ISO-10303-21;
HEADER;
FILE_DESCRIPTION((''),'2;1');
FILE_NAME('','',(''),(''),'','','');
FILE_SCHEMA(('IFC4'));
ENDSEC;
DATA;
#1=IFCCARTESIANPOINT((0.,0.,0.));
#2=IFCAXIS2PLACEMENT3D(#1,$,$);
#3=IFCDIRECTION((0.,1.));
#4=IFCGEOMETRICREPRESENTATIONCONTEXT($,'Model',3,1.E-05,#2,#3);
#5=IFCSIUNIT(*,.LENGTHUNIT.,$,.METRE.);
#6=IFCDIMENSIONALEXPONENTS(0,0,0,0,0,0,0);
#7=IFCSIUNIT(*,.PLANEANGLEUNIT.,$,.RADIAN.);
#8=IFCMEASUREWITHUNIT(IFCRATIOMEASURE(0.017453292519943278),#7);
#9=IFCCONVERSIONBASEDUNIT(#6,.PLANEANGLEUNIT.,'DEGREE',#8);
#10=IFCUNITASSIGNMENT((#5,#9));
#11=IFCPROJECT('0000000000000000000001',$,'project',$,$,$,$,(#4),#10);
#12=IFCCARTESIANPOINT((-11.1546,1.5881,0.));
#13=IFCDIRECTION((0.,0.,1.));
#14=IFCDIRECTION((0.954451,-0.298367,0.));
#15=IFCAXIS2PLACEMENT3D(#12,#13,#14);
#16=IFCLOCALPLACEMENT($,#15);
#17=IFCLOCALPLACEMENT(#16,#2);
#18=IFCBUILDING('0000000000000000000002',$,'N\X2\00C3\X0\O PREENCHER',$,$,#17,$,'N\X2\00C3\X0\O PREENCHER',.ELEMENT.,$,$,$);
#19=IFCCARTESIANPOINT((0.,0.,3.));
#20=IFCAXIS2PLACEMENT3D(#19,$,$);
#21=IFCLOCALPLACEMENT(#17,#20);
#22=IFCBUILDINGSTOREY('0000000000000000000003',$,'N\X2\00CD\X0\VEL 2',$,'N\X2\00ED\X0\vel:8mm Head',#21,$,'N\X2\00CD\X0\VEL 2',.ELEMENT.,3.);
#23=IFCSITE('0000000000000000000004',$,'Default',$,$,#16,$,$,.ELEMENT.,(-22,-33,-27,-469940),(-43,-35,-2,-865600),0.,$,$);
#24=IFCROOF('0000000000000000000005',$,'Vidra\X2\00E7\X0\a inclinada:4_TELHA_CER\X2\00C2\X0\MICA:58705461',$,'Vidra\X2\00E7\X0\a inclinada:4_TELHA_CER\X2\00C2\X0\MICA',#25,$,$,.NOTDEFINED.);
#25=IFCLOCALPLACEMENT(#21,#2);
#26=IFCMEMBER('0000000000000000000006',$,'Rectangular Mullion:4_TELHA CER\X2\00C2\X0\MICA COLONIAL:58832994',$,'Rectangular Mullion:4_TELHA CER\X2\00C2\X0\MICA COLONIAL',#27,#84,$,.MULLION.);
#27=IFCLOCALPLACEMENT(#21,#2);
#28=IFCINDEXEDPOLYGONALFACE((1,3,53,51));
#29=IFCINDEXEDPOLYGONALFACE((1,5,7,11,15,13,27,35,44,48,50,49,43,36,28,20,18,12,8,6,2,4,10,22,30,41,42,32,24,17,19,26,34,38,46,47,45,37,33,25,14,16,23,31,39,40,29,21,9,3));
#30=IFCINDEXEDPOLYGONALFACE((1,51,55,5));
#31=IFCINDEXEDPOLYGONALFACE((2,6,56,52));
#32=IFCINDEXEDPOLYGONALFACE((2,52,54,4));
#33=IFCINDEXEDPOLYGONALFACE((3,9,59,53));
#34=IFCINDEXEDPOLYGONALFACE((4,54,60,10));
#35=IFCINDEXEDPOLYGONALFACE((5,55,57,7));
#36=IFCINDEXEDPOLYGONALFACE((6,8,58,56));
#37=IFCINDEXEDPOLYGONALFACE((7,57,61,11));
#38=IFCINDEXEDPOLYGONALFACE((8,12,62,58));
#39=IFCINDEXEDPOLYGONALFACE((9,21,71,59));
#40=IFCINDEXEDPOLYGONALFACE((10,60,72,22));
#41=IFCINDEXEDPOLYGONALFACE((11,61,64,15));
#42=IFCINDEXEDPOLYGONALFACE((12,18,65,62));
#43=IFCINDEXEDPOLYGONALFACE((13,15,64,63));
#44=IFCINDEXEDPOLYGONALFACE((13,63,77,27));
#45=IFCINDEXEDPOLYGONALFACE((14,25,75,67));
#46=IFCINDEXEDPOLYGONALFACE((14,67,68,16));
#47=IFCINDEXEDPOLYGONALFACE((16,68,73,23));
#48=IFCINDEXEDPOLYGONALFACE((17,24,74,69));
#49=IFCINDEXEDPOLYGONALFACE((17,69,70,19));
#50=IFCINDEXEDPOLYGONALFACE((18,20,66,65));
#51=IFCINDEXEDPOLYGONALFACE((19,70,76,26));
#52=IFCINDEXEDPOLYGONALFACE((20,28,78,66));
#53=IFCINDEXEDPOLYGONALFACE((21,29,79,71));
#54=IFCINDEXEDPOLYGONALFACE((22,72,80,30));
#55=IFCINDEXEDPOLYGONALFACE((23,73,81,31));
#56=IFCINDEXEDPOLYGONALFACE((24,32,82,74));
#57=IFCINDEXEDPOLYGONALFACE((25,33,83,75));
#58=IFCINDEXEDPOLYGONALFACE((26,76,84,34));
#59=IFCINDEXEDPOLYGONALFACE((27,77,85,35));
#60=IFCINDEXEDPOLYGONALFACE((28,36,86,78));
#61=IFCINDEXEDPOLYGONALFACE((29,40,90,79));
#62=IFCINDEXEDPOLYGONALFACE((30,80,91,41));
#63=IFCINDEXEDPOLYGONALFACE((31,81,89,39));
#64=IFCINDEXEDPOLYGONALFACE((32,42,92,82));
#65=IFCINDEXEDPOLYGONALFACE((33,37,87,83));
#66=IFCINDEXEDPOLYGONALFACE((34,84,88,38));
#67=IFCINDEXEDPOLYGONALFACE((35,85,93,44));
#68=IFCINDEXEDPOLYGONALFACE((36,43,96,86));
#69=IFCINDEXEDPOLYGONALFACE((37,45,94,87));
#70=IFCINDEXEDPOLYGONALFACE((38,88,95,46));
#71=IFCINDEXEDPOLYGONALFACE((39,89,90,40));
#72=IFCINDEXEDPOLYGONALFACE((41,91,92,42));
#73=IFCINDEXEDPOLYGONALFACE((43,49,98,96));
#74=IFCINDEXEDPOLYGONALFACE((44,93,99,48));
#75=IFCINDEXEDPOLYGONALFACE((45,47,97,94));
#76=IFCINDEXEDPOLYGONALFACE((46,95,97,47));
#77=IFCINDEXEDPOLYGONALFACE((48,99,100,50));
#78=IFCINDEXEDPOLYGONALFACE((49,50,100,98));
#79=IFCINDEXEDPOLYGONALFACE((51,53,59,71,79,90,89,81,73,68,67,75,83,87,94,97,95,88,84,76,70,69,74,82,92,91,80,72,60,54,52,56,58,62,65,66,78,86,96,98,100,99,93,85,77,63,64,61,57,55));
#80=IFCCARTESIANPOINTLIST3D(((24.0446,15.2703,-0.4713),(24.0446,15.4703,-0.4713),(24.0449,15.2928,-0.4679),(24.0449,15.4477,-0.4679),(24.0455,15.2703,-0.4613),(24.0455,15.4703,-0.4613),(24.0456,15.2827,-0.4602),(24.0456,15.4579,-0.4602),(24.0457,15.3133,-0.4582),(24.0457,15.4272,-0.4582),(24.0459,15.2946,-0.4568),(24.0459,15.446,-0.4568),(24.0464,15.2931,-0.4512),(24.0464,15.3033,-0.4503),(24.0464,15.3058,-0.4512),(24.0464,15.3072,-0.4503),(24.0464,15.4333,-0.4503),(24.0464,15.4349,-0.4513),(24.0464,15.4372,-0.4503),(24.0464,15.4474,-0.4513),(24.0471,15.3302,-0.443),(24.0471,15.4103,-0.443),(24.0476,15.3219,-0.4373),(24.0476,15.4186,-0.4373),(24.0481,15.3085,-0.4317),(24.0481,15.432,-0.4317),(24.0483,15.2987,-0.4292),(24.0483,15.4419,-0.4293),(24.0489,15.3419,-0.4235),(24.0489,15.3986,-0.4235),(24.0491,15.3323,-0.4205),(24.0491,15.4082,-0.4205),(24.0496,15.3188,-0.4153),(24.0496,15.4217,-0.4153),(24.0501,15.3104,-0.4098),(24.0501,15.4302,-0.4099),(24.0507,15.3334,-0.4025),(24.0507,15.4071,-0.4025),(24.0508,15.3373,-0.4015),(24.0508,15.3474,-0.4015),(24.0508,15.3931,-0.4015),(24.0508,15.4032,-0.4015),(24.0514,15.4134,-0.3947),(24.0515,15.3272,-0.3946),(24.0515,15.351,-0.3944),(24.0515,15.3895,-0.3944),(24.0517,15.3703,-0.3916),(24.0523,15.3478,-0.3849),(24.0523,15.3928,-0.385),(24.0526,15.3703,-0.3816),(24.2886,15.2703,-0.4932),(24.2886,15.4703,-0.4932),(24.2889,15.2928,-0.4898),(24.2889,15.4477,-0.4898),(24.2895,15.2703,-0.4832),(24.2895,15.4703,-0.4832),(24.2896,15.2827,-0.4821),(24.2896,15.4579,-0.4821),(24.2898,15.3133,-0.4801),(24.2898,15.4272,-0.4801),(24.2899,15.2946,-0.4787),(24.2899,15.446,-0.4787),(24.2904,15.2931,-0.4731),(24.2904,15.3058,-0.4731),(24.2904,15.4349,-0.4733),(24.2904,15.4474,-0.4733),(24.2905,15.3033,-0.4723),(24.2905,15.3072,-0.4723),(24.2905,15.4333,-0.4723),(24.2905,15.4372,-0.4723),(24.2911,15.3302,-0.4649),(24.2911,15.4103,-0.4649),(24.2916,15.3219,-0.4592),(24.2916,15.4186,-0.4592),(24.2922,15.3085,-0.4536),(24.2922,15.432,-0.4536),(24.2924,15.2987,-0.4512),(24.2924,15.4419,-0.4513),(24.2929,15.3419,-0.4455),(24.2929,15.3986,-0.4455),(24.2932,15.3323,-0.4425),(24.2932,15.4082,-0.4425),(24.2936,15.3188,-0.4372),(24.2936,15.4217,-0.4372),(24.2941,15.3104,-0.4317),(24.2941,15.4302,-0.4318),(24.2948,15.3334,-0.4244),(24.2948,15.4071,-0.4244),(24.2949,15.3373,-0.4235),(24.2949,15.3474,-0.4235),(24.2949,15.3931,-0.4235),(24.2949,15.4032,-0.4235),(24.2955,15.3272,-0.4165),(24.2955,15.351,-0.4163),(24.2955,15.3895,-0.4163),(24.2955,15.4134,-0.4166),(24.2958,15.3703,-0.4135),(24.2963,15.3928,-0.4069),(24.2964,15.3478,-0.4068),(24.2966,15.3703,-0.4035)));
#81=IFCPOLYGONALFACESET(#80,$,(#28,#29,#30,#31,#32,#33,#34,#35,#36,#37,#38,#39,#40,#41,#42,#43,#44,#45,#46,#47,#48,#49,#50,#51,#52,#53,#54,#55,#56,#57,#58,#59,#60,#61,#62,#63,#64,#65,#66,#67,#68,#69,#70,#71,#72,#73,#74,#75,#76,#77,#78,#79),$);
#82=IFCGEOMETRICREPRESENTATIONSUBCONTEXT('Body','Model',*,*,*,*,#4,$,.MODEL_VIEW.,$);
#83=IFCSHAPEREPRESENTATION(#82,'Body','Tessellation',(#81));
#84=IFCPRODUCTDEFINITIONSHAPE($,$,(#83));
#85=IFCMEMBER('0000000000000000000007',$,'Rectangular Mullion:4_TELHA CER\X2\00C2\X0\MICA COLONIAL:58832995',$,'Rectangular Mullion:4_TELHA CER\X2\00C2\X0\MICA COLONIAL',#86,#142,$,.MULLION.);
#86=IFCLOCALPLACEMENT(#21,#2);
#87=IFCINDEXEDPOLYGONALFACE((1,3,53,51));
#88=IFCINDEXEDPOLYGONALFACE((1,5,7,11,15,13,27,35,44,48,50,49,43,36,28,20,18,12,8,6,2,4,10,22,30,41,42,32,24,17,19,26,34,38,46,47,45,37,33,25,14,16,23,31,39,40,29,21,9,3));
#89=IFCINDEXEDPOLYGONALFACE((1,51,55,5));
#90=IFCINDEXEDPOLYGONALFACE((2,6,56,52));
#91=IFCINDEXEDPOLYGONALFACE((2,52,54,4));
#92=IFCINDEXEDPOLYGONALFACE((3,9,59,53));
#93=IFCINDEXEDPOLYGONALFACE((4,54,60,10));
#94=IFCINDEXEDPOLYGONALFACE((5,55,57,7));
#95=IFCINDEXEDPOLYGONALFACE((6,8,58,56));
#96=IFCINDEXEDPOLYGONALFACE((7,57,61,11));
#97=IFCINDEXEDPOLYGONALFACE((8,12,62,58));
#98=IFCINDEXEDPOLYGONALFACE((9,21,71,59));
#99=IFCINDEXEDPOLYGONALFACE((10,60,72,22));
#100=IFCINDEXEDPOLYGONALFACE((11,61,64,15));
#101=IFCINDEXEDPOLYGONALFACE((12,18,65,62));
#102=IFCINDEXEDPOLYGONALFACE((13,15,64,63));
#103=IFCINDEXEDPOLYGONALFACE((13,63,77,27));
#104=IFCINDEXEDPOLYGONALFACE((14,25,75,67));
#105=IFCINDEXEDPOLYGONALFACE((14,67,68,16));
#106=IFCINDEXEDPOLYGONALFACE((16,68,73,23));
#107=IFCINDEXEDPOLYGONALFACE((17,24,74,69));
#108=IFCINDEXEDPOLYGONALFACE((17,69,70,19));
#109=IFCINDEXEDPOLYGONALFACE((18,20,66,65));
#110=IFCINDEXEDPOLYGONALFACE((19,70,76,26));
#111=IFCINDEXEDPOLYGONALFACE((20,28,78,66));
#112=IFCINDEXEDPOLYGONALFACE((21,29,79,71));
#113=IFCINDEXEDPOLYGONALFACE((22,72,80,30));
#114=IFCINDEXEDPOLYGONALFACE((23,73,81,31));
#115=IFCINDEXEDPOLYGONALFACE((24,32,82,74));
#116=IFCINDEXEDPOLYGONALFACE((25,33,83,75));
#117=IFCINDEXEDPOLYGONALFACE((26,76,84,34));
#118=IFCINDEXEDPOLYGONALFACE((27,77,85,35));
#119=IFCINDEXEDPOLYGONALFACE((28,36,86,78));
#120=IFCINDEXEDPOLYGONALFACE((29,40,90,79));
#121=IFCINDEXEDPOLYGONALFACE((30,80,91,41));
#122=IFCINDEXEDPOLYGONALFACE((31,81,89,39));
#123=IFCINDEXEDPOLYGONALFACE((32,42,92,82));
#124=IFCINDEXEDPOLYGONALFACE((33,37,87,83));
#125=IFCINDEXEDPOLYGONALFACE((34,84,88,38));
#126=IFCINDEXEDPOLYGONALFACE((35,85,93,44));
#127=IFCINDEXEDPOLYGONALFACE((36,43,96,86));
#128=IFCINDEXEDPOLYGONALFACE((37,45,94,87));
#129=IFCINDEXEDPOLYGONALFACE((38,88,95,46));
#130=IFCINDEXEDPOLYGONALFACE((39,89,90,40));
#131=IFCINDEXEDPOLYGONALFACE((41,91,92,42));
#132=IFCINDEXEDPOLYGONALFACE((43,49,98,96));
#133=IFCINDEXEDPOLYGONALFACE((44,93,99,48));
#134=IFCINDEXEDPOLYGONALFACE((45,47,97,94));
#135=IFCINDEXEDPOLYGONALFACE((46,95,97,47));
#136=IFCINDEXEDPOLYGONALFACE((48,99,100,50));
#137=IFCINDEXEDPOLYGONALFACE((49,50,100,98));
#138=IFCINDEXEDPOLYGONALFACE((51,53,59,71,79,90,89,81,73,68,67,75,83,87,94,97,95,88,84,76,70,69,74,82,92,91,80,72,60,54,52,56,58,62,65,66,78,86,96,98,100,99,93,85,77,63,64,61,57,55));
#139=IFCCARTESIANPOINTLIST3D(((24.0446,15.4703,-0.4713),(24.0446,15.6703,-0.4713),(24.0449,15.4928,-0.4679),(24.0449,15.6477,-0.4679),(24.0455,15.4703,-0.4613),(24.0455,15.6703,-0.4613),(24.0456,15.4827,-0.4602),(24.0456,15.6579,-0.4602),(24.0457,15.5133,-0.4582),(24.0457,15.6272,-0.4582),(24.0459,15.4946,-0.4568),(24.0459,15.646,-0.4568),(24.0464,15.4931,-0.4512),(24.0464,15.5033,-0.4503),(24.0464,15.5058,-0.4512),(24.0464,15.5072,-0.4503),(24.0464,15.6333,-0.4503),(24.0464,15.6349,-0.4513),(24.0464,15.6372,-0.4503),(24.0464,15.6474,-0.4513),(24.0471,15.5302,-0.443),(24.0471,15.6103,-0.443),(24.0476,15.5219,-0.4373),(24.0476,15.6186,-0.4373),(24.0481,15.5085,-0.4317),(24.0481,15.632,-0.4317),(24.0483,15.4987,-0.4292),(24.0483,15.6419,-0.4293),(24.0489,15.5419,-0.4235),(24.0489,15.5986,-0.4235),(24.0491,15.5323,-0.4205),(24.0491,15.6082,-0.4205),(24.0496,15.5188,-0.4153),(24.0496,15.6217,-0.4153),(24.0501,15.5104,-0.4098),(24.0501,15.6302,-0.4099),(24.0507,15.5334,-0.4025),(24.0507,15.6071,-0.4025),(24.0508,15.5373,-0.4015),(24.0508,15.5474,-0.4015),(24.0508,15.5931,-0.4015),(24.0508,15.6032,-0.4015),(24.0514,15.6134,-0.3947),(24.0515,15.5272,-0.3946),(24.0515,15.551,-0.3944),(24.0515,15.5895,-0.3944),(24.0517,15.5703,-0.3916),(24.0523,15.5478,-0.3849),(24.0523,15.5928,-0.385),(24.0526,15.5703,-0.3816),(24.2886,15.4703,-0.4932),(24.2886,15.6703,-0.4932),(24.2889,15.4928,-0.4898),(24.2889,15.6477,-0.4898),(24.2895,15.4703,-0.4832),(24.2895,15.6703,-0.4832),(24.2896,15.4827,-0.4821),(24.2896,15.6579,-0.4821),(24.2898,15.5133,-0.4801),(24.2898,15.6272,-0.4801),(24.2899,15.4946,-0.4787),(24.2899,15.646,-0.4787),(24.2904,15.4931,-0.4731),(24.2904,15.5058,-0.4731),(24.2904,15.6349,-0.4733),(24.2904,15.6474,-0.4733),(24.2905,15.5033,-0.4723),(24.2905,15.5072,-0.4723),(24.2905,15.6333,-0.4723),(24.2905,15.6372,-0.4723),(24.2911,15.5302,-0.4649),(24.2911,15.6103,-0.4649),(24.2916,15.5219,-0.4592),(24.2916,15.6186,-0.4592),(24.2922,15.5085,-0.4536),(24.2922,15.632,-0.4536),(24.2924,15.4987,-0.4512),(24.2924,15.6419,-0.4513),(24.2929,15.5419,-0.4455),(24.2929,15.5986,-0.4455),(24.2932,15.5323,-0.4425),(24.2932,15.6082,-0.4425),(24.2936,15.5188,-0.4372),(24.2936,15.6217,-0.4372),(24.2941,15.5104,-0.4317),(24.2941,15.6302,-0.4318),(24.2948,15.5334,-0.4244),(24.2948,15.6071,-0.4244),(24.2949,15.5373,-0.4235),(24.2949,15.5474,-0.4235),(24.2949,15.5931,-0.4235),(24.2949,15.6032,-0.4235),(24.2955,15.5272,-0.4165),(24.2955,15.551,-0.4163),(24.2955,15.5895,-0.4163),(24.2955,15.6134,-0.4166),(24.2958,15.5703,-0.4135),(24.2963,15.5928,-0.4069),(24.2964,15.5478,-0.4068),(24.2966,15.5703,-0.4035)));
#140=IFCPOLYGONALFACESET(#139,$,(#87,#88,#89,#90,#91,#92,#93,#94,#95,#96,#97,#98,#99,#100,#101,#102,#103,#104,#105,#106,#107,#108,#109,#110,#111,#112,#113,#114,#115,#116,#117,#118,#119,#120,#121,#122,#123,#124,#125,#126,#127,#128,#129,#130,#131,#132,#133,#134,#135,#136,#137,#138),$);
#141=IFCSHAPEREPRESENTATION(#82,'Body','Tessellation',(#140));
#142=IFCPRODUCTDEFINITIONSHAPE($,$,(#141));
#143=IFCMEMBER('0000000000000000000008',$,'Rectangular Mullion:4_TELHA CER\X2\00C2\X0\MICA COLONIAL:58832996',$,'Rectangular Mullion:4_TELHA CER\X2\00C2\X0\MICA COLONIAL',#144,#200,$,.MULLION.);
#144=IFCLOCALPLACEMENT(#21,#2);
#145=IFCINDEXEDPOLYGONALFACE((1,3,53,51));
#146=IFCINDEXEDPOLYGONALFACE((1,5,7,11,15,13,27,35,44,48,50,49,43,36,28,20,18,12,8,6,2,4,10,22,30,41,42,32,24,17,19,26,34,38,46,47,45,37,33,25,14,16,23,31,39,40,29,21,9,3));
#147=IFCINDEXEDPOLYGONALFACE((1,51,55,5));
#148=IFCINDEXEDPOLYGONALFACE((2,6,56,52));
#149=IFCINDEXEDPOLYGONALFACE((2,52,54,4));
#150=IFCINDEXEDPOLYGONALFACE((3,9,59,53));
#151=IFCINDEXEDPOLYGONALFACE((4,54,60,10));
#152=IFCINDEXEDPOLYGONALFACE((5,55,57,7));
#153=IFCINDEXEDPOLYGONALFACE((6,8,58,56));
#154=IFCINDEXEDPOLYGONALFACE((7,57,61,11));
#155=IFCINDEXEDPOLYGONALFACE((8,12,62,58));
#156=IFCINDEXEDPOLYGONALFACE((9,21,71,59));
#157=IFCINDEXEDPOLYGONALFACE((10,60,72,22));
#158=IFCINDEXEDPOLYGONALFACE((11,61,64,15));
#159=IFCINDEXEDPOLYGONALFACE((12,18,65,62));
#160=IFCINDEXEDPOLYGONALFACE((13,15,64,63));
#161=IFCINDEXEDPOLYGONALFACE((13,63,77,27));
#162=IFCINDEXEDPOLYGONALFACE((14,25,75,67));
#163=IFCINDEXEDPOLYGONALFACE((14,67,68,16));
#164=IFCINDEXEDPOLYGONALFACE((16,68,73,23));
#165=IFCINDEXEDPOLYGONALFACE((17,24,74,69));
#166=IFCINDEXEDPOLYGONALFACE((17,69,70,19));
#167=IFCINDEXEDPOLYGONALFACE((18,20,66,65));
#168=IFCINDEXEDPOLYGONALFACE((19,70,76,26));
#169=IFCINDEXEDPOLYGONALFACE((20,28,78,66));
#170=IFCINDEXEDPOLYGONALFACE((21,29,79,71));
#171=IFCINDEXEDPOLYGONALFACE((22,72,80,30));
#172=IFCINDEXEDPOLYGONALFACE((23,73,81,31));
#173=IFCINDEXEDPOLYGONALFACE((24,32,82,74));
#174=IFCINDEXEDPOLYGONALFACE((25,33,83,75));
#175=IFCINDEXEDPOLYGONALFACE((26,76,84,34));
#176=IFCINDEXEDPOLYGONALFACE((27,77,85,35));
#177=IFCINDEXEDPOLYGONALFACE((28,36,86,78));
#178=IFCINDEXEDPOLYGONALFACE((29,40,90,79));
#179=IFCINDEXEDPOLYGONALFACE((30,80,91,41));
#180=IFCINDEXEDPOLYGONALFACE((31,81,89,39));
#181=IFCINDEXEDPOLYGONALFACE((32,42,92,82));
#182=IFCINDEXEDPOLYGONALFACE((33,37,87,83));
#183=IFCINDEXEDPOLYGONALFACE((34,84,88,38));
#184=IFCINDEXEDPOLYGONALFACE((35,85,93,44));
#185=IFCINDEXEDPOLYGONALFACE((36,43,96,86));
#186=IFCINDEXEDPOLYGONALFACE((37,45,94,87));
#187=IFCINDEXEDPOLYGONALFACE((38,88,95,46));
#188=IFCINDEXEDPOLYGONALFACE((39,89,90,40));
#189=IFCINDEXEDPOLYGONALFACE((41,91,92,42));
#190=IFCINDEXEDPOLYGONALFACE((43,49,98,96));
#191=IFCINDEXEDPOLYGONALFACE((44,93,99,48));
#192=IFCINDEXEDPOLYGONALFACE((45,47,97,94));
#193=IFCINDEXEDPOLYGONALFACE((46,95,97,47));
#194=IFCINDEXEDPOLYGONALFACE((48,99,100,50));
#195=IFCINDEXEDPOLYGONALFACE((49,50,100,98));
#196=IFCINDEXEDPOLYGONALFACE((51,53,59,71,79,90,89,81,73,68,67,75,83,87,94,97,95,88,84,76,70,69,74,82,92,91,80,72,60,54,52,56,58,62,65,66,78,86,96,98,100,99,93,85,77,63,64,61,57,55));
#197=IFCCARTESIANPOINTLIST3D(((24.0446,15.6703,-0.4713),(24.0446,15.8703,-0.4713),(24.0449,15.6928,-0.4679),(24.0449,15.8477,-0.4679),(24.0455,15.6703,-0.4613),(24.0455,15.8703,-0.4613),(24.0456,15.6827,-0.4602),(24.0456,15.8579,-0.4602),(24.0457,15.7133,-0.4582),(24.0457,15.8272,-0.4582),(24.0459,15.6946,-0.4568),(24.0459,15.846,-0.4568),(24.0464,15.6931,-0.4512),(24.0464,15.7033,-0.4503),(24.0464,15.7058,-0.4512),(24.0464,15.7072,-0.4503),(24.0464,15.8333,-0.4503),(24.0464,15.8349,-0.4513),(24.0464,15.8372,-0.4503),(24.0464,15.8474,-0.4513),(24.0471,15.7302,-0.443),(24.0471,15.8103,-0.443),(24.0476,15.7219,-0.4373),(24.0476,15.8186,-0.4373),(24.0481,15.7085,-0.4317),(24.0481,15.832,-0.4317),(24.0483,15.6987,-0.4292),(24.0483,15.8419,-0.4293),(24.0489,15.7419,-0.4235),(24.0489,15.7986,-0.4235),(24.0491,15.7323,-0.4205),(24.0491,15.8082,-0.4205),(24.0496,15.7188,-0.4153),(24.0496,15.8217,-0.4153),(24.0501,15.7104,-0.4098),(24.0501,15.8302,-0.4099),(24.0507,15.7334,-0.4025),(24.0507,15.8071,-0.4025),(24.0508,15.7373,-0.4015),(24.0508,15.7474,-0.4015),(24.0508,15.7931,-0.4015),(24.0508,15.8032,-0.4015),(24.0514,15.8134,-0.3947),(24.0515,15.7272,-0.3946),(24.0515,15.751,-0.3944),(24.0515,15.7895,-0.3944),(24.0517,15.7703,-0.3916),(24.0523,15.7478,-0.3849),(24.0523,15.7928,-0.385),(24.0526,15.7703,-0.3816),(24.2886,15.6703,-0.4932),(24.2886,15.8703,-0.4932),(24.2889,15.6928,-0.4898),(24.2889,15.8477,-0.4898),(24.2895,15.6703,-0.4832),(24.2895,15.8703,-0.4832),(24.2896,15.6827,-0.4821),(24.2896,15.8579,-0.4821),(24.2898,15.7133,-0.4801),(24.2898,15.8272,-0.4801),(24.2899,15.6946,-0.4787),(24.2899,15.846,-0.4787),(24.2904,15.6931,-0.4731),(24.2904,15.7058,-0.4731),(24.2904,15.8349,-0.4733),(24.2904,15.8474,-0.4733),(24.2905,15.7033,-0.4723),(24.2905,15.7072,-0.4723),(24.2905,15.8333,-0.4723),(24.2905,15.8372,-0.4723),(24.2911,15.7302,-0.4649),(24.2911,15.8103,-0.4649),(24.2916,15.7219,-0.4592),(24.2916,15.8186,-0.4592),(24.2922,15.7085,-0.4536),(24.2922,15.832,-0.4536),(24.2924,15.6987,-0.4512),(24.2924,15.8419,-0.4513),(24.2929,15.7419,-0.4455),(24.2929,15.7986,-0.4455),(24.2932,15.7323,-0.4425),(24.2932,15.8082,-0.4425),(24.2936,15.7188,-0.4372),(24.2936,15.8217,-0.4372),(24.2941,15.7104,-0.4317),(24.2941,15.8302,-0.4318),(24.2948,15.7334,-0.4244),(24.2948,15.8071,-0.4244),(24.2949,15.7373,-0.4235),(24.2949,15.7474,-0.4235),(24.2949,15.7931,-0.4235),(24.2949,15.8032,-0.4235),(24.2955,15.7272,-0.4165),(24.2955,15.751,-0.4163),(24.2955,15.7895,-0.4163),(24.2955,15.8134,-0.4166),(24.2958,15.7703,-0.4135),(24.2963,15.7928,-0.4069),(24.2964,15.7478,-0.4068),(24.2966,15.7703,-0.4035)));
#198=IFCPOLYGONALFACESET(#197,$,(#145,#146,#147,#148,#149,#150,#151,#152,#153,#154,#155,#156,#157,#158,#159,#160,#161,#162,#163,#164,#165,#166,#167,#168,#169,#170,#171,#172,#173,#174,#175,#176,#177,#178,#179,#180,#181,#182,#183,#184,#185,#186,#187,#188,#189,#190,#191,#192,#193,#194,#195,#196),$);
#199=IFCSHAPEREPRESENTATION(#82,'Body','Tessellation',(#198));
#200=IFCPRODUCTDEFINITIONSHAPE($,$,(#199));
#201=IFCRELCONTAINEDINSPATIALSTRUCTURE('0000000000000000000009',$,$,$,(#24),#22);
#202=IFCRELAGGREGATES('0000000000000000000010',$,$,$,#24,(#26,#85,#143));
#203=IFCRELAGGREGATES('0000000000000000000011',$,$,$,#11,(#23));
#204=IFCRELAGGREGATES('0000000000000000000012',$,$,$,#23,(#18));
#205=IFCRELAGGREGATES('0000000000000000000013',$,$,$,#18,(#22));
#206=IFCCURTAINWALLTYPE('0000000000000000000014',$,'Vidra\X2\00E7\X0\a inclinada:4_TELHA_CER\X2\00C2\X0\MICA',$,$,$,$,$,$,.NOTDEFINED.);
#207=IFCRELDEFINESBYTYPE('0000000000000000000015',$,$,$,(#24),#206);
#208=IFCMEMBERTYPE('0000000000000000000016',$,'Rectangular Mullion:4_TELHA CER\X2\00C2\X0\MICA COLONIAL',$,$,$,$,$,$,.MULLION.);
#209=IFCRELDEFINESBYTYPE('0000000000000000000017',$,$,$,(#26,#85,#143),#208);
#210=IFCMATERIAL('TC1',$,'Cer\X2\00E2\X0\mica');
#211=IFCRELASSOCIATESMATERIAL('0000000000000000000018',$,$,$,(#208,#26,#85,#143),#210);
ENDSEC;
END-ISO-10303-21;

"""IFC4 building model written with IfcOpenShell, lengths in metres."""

from ifc_helpers import new_model, entity, si_unit, converted_unit, direction, frame, origin, place, context, subcontext, project, spatial, line, arc, indexed_curve, outline, extrude, source, transform, mapped, material, type_object, type_shapes, element, aggregate, save


model = new_model("IFC4")

# Units and contexts
model_context = context("Model", 3, precision=1e-05, world=origin(), true_north=direction((0.0, 1.0)))
body_context = subcontext(model_context, "Body", "Model", "MODEL_VIEW")
ifc_project = project(units=[si_unit("LENGTHUNIT", "METRE"), converted_unit("PLANEANGLEUNIT", "DEGREE", entity("IfcRatioMeasure", 0.017453292519943278), si_unit("PLANEANGLEUNIT", "RADIAN"), dimensions=[0, 0, 0, 0, 0, 0, 0])], contexts=[model_context])

# Site, building, storey
site_placement = place(None, frame((-11.1546, 1.5881, 0.0), z_axis=(0.0, 0.0, 1.0), x_axis=(0.954451, -0.298367, 0.0)))
site = spatial("IfcSite", under=ifc_project, at=site_placement, Name="Default", CompositionType="ELEMENT", RefLatitude=(-22, -33, -27, -469940), RefLongitude=(-43, -35, -2, -865600), RefElevation=0.0)
building_placement = place(site_placement, origin())
building = spatial("IfcBuilding", under=site, at=building_placement, Name="NÃO PREENCHER", LongName="NÃO PREENCHER", CompositionType="ELEMENT")
storey_placement = place(building_placement, frame((0.0, 0.0, 3.0)))
storey = spatial("IfcBuildingStorey", under=building, at=storey_placement, Name="NÍVEL 2", ObjectType="Nível:8mm Head", LongName="NÍVEL 2", CompositionType="ELEMENT", Elevation=3.0)

# Roof, members
curtain_wall_type = type_object("IfcCurtainWallType", Name="Vidraça inclinada:4_TELHA_CERÂMICA", PredefinedType="NOTDEFINED")
roof_placement = place(storey_placement, frame((0.0, 0.0, -3.0)))
roof = element("IfcRoof", 1, at=roof_placement, inside=storey, type_object=curtain_wall_type, Name="Vidraça inclinada:4_TELHA_CERÂMICA:58705461", ObjectType="Vidraça inclinada:4_TELHA_CERÂMICA", PredefinedType="NOTDEFINED")
ifc_material_1 = material(Name="TC1", Category="Cerâmica")
member_type_1 = type_object("IfcMemberType", Name="Rectangular Mullion:4_TELHA CERÂMICA COLONIAL", PredefinedType="MULLION", material=ifc_material_1)
shared_shape_1 = source(origin(), body_context, "Body", "SweptSolid", [
    extrude(outline(indexed_curve([(-0.029, -0.1), (-0.019, -0.1), (-0.0164, -0.0815), (-0.0089, -0.0645), (-0.0089, -0.0771), (0.061, 0.0), (-0.009, 0.0771), (-0.009, 0.0646), (-0.0165, 0.0816), (-0.019, 0.1), (-0.029, 0.1), (-0.0089, 0.0479), (0.041, 0.0229), (0.041, 0.0329), (0.0131, 0.0425), (-0.008, 0.0631), (-0.008, 0.067), (0.051, 0.0), (-0.008, -0.067), (-0.008, -0.0631), (0.0131, -0.0425), (0.041, -0.0329), (0.041, -0.0229), (-0.0089, -0.0479)], segments=[line(1, 2), arc(2, 3, 4), line(4, 5), arc(5, 6, 7), line(7, 8), arc(8, 9, 10), line(10, 11), arc(11, 12, 13), line(13, 14), arc(14, 15, 16), line(16, 17), arc(17, 18, 19), line(19, 20), arc(20, 21, 22), line(22, 23), arc(23, 24, 1)], self_intersect=False)), frame((0.0, -0.029, -0.245), z_axis=(0.0, 0.0, 1.0), x_axis=(0.0, -1.0, 0.0)), (0.0, 0.0, 1.0), 0.245),
])
type_shapes(member_type_1, [shared_shape_1])
member_1_placement = place(roof_placement, frame((24.0446, 15.3703, 2.5287), z_axis=(-0.99599, 0.0, 0.089469), x_axis=(0.0, 1.0, 0.0)))
member_1 = element("IfcMember", 2, at=member_1_placement, type_object=member_type_1, material=ifc_material_1, Name="Rectangular Mullion:4_TELHA CERÂMICA COLONIAL:58832994", ObjectType="Rectangular Mullion:4_TELHA CERÂMICA COLONIAL", PredefinedType="MULLION", context=body_context, shape_type="MappedRepresentation", body=[
    mapped(shared_shape_1, transform((0.0, 0.0, 0.0), scale=1.0)),
])
member_2_placement = place(roof_placement, frame((24.0446, 15.5703, 2.5287), z_axis=(-0.99599, 0.0, 0.089469), x_axis=(0.0, 1.0, 0.0)))
member_2 = element("IfcMember", 3, at=member_2_placement, type_object=member_type_1, material=ifc_material_1, Name="Rectangular Mullion:4_TELHA CERÂMICA COLONIAL:58832995", ObjectType="Rectangular Mullion:4_TELHA CERÂMICA COLONIAL", PredefinedType="MULLION", context=body_context, shape_type="MappedRepresentation", body=[
    mapped(shared_shape_1, transform((0.0, 0.0, 0.0), scale=1.0)),
])
member_3_placement = place(roof_placement, frame((24.0446, 15.7703, 2.5287), z_axis=(-0.99599, 0.0, 0.089469), x_axis=(0.0, 1.0, 0.0)))
member_3 = element("IfcMember", 4, at=member_3_placement, type_object=member_type_1, material=ifc_material_1, Name="Rectangular Mullion:4_TELHA CERÂMICA COLONIAL:58832996", ObjectType="Rectangular Mullion:4_TELHA CERÂMICA COLONIAL", PredefinedType="MULLION", context=body_context, shape_type="MappedRepresentation", body=[
    mapped(shared_shape_1, transform((0.0, 0.0, 0.0), scale=1.0)),
])
aggregate(roof, [member_1, member_2, member_3])

save(model, "model.ifc")
